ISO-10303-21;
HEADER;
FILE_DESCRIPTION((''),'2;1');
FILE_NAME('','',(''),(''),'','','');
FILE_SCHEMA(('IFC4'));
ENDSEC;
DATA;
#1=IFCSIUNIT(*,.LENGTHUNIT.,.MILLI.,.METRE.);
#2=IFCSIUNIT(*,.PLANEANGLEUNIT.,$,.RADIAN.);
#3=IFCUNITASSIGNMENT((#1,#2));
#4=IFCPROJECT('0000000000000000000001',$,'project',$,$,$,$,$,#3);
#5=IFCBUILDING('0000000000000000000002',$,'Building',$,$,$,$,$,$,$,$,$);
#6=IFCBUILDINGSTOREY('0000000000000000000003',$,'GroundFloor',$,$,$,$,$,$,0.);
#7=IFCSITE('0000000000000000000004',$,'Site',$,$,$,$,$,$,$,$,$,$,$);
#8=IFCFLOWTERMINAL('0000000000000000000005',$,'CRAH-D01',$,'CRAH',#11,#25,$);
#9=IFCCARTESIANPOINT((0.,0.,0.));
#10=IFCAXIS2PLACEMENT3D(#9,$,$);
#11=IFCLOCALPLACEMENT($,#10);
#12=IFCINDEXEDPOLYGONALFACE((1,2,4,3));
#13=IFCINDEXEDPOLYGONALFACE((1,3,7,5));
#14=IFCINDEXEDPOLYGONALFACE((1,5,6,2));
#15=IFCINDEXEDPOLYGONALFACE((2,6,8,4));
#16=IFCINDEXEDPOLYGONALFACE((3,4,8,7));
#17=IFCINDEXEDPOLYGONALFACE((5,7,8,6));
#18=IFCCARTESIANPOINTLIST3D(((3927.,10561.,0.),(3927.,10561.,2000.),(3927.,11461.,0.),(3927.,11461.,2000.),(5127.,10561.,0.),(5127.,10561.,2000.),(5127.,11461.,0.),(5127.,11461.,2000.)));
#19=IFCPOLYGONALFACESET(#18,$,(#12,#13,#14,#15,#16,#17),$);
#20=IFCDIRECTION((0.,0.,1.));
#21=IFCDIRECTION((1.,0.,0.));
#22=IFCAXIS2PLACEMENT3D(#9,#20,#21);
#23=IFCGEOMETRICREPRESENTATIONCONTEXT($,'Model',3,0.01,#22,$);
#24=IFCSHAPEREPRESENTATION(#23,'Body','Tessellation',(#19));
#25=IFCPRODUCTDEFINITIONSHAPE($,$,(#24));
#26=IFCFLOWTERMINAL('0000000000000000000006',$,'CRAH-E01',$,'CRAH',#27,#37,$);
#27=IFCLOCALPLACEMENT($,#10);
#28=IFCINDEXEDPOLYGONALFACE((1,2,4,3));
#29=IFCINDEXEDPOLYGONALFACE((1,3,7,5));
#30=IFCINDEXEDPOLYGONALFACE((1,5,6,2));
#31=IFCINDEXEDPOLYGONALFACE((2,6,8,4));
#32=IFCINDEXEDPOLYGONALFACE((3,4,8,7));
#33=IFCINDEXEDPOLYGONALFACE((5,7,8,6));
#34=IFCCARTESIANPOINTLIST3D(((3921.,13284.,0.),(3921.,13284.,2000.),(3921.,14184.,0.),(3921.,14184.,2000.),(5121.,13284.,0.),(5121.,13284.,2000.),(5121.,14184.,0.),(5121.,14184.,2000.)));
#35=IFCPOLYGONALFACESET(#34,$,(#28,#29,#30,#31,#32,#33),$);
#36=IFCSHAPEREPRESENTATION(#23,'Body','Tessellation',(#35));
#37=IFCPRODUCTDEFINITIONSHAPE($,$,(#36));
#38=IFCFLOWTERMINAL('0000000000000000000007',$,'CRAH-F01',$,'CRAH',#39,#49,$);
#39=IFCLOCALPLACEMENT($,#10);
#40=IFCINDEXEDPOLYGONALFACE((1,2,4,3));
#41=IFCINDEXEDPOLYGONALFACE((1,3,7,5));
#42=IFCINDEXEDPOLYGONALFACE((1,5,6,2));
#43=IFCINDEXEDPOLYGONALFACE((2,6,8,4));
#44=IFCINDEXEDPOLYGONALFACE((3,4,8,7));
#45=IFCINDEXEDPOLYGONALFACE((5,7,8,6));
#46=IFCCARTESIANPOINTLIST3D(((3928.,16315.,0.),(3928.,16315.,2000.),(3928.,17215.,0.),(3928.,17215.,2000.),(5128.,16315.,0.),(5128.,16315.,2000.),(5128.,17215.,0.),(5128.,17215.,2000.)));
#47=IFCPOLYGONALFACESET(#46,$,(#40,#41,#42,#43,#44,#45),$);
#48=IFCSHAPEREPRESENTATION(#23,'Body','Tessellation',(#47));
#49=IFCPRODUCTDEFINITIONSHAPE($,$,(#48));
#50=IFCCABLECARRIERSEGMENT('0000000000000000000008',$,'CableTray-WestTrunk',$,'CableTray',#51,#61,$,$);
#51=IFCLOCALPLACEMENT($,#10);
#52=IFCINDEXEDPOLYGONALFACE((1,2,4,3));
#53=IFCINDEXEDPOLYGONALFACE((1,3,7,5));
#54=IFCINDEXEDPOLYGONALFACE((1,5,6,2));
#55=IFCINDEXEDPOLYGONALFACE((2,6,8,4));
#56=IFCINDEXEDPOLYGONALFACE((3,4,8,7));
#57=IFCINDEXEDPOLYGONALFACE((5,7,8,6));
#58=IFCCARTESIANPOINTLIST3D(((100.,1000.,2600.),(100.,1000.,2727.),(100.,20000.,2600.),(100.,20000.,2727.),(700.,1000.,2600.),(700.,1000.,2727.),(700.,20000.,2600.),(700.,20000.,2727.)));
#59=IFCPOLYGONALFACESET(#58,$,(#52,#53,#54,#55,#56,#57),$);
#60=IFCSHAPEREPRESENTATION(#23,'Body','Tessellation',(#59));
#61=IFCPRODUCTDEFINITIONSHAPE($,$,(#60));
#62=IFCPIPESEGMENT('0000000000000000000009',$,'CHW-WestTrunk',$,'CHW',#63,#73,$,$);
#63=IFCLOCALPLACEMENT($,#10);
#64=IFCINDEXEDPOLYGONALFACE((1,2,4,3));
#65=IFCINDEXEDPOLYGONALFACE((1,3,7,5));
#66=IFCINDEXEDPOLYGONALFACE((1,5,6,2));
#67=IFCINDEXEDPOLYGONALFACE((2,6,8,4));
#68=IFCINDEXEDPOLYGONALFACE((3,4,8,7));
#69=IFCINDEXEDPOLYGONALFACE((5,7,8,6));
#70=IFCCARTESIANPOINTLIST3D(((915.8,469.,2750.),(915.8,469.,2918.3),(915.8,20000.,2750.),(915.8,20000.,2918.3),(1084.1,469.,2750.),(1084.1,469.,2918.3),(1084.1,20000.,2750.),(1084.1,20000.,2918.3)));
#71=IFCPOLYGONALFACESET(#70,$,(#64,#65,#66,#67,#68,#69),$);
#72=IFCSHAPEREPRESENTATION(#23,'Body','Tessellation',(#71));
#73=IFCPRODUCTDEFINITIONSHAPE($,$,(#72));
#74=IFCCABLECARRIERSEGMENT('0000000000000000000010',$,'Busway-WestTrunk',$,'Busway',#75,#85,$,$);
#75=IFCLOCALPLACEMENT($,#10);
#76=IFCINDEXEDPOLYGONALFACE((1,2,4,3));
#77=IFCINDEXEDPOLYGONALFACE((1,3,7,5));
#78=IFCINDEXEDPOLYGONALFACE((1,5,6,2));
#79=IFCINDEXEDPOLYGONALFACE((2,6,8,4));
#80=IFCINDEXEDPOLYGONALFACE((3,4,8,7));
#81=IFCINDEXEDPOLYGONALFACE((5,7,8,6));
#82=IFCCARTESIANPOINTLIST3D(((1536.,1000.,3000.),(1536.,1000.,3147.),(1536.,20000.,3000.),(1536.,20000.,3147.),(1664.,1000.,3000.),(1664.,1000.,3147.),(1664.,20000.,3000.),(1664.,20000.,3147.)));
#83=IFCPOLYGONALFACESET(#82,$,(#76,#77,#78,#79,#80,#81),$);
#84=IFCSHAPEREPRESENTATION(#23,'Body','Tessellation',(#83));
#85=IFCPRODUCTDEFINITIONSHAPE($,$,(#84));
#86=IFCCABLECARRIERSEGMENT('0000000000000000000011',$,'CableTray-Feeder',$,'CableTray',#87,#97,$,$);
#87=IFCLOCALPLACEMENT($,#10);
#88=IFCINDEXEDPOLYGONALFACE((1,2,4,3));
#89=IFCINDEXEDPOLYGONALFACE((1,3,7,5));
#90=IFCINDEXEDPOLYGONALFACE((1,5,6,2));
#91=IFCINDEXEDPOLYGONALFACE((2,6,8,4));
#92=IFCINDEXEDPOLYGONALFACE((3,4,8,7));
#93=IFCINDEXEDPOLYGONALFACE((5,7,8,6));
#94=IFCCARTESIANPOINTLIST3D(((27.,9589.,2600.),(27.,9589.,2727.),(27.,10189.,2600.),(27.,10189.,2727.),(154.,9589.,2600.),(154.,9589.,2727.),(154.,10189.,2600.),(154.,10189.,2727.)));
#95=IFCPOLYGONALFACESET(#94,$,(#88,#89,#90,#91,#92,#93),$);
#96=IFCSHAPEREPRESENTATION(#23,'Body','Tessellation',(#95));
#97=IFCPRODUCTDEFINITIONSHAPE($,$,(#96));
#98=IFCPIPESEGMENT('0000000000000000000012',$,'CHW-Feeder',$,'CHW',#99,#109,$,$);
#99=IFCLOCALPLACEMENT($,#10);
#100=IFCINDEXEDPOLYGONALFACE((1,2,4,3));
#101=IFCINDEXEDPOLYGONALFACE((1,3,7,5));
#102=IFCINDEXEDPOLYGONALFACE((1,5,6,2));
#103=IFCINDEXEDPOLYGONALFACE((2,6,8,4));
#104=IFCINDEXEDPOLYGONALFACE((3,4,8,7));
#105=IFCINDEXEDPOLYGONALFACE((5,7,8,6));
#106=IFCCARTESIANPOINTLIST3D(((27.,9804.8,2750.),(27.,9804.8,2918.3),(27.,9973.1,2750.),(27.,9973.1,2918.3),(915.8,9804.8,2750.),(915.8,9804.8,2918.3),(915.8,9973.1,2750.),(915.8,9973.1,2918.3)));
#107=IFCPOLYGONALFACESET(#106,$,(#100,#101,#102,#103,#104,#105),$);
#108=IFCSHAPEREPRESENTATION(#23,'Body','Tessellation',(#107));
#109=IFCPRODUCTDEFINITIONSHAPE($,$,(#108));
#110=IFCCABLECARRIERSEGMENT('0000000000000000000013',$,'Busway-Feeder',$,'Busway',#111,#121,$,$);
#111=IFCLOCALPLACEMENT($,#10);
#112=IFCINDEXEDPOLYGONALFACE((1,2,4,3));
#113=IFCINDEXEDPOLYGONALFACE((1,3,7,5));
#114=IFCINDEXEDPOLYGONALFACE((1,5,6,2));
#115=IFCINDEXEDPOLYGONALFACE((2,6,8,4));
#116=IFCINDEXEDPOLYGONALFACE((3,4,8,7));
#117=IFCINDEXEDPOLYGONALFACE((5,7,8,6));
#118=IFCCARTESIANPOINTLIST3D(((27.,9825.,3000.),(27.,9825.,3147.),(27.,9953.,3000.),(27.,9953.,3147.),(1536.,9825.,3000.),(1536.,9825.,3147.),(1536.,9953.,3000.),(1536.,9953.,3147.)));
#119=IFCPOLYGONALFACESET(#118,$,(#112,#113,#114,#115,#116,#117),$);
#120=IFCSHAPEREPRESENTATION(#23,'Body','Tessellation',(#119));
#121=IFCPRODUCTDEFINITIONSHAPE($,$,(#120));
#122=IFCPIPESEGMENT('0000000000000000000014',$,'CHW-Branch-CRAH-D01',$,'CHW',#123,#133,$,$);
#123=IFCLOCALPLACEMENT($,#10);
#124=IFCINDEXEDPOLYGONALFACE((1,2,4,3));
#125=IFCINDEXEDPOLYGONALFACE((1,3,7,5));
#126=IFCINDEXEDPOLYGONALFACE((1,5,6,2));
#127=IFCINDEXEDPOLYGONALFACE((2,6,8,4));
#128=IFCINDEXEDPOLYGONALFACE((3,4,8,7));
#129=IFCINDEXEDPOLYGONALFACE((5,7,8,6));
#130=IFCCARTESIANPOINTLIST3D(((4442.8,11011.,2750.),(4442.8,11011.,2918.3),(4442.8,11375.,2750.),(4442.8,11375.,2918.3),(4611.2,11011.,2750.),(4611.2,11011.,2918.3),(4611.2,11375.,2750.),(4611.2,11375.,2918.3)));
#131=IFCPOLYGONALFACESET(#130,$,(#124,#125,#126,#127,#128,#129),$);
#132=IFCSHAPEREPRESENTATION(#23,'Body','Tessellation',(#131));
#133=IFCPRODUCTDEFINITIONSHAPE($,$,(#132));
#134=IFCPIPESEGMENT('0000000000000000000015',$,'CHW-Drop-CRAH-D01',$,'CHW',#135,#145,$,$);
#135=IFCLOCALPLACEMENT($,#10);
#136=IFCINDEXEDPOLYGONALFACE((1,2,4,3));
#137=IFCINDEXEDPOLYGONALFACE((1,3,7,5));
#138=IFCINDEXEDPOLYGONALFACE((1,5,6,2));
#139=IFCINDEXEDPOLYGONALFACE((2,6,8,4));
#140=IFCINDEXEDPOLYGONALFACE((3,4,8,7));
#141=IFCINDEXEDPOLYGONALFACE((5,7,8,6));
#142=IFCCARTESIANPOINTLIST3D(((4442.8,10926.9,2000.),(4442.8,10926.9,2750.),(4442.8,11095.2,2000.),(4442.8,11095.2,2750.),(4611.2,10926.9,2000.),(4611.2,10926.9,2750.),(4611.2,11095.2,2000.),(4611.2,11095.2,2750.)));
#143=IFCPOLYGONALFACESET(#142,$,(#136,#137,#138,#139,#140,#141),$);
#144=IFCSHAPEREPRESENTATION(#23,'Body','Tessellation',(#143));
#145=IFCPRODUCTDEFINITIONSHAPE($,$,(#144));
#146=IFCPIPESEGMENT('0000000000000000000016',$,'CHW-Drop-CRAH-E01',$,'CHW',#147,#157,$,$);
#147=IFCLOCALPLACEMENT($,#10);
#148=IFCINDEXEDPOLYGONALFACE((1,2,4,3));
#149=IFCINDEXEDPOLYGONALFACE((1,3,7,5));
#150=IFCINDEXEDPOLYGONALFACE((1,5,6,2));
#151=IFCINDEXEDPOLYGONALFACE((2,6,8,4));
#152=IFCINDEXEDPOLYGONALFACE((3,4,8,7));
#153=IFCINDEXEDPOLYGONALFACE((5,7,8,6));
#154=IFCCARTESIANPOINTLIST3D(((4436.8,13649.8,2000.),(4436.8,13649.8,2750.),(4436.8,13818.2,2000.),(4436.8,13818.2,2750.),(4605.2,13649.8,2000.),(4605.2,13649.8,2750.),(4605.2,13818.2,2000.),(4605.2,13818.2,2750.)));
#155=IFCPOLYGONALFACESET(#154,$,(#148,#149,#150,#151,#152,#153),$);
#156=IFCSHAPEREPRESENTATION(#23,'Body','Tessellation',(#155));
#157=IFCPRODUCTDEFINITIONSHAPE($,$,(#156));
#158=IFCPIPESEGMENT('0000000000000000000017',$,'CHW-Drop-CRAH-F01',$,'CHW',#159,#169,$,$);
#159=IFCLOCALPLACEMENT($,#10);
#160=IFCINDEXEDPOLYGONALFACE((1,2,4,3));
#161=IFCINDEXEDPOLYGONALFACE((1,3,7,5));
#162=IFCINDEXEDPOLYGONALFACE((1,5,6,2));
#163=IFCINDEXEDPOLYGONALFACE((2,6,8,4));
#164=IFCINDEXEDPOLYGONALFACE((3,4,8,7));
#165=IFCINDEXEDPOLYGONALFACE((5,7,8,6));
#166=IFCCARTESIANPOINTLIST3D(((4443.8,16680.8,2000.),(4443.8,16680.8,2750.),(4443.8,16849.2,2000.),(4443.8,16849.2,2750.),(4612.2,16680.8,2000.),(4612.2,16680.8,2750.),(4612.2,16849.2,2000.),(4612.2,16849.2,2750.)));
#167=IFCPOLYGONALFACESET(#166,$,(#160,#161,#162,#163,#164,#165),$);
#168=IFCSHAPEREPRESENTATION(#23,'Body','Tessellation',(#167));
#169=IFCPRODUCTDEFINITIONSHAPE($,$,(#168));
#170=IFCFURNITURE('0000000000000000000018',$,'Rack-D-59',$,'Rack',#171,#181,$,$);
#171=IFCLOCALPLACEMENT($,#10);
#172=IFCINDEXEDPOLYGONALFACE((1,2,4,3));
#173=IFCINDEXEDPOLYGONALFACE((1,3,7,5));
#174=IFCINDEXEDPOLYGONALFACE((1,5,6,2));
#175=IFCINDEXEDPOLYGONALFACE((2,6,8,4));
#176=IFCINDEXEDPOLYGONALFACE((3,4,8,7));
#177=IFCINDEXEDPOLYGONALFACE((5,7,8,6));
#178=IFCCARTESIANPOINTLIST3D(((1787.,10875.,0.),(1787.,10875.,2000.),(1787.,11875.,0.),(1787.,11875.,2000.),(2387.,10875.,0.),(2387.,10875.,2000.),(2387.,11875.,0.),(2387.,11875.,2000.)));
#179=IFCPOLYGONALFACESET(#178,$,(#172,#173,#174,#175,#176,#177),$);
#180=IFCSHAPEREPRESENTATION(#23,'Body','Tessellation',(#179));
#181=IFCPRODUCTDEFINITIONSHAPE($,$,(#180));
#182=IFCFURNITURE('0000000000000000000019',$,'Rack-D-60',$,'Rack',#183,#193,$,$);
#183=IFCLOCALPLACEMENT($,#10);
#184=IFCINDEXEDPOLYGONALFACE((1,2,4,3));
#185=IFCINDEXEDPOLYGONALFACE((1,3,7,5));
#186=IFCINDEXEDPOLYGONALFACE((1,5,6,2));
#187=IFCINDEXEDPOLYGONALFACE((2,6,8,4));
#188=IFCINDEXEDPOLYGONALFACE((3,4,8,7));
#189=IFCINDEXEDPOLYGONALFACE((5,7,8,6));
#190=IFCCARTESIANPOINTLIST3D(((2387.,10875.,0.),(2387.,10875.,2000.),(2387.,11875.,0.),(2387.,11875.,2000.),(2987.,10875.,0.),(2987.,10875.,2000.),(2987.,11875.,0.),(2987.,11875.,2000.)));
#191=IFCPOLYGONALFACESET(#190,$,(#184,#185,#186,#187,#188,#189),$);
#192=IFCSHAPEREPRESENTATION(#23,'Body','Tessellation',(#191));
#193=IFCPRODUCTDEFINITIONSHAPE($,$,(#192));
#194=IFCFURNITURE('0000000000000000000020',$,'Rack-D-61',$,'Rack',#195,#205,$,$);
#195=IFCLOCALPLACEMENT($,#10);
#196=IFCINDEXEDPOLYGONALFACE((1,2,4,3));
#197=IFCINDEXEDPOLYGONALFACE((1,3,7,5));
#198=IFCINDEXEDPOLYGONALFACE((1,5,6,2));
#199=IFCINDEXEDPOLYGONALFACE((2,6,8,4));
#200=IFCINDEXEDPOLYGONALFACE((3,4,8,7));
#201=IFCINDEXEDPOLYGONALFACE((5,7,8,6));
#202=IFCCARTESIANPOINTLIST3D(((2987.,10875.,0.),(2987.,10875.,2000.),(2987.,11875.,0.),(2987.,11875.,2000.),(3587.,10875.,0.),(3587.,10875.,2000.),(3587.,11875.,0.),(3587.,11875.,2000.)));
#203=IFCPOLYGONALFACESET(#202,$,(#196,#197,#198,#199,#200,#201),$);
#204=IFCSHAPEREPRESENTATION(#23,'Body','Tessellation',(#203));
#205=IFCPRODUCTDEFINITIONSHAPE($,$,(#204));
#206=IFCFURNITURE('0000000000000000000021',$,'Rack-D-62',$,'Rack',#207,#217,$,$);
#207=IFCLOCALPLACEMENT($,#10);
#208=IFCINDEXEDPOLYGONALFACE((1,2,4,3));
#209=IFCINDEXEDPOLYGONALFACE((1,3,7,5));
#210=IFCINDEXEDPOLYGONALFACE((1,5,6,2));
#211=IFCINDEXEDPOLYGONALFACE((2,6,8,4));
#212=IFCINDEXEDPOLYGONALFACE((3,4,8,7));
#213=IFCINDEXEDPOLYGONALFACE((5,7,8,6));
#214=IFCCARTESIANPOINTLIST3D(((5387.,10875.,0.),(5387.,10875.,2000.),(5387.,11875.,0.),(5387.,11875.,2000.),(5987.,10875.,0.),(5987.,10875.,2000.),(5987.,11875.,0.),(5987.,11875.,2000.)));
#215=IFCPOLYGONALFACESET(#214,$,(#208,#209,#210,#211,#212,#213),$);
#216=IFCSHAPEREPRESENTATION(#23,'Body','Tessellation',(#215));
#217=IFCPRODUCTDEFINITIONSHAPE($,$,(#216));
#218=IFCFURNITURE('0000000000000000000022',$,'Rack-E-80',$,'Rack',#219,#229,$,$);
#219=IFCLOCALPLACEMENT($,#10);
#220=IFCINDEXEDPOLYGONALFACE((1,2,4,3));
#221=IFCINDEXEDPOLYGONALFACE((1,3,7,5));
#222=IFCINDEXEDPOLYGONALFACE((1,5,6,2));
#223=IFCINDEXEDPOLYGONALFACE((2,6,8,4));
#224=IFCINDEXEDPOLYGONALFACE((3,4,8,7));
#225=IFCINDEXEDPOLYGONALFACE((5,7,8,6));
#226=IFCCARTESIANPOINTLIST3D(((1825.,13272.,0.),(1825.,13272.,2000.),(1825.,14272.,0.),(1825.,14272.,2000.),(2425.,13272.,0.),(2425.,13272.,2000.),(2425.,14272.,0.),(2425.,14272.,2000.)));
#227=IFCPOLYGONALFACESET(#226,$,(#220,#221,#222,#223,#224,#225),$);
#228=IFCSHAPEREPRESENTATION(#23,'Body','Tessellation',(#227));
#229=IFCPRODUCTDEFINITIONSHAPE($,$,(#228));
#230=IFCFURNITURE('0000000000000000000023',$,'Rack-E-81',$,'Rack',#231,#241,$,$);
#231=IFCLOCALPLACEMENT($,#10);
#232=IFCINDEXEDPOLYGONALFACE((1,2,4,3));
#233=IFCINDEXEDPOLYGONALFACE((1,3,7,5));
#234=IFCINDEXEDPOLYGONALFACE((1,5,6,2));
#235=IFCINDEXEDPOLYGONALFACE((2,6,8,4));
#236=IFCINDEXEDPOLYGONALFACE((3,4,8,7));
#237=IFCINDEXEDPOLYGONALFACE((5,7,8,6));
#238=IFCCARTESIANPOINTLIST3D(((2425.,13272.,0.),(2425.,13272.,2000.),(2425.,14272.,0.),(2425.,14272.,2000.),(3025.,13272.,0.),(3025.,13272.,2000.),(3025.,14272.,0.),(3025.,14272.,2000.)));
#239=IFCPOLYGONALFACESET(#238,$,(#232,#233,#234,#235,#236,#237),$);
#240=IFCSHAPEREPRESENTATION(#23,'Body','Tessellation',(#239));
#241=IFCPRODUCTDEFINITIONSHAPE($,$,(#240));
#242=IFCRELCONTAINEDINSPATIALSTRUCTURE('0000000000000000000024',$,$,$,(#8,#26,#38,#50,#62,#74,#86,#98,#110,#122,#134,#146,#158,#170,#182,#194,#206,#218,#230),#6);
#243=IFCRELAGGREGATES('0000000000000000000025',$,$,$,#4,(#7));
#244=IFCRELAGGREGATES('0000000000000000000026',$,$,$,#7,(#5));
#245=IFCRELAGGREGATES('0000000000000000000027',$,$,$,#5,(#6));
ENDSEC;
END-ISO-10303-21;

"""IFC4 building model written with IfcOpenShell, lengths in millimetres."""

from ifc_helpers import new_model, si_unit, frame, origin, origin_with_axes, origin_2d, place, context, project, spatial, rectangle, extrude, element, save


model = new_model("IFC4")

# Units and contexts
model_context = context("Model", 3, precision=0.01, world=origin_with_axes())
ifc_project = project(units=[si_unit("LENGTHUNIT", "METRE", prefix="MILLI"), si_unit("PLANEANGLEUNIT", "RADIAN")])

# Site, building, storey
site = spatial("IfcSite", under=ifc_project, Name="Site")
building = spatial("IfcBuilding", under=site, Name="Building")
storey = spatial("IfcBuildingStorey", under=building, Name="GroundFloor", Elevation=0.0)

# Flow terminals
for number, where, z_axis, x_axis, name in (
    (1, (4527.0, 11011.0, 0.0), (0.0, 0.0, 1.0), (1.0, 0.0, 0.0), "CRAH-D01"),
    (2, (4521.0, 13734.0, 0.0), (0.0, 0.0, 1.0), (1.0, 0.0, 0.0), "CRAH-E01"),
    (3, (4528.0, 16765.0, 0.0), (0.0, 0.0, 1.0), (1.0, 0.0, 0.0), "CRAH-F01"),
):
    element("IfcFlowTerminal", number, at=place(None, frame(where, z_axis=z_axis, x_axis=x_axis)), inside=storey, Name=name, ObjectType="CRAH", context=model_context, shape_type="SweptSolid", body=[
        extrude(rectangle(XDim=1200.0, YDim=900.0, at=origin_2d()), origin(), (0.0, 0.0, 1.0), 2000.0),
    ])

# Cable carrier segment
cable_carrier_segment_1_placement = place(None, frame((400.0, 10500.0, 2600.0), z_axis=(0.0, 0.0, 1.0), x_axis=(1.0, 0.0, 0.0)))
element("IfcCableCarrierSegment", 4, at=cable_carrier_segment_1_placement, inside=storey, Name="CableTray-WestTrunk", ObjectType="CableTray", context=model_context, shape_type="SweptSolid", body=[
    extrude(rectangle(XDim=600.0, YDim=19000.0, at=origin_2d()), origin(), (0.0, 0.0, 1.0), 127.0),
])

# Pipe segment
pipe_segment_1_placement = place(None, frame((1000.0, 10234.5, 2750.0), z_axis=(0.0, 0.0, 1.0), x_axis=(1.0, 0.0, 0.0)))
element("IfcPipeSegment", 5, at=pipe_segment_1_placement, inside=storey, Name="CHW-WestTrunk", ObjectType="CHW", context=model_context, shape_type="SweptSolid", body=[
    extrude(rectangle(XDim=168.3, YDim=19531.0, at=origin_2d()), origin(), (0.0, 0.0, 1.0), 168.3),
])

# Cable carrier segments
cable_carrier_segment_2_placement = place(None, frame((1600.0, 10500.0, 3000.0), z_axis=(0.0, 0.0, 1.0), x_axis=(1.0, 0.0, 0.0)))
element("IfcCableCarrierSegment", 6, at=cable_carrier_segment_2_placement, inside=storey, Name="Busway-WestTrunk", ObjectType="Busway", context=model_context, shape_type="SweptSolid", body=[
    extrude(rectangle(XDim=128.0, YDim=19000.0, at=origin_2d()), origin(), (0.0, 0.0, 1.0), 147.0),
])
cable_carrier_segment_3_placement = place(None, frame((90.5, 9889.0, 2600.0), z_axis=(0.0, 0.0, 1.0), x_axis=(1.0, 0.0, 0.0)))
element("IfcCableCarrierSegment", 7, at=cable_carrier_segment_3_placement, inside=storey, Name="CableTray-Feeder", ObjectType="CableTray", context=model_context, shape_type="SweptSolid", body=[
    extrude(rectangle(XDim=127.0, YDim=600.0, at=origin_2d()), origin(), (0.0, 0.0, 1.0), 127.0),
])

# Pipe segment
pipe_segment_2_placement = place(None, frame((471.4, 9889.0, 2750.0), z_axis=(0.0, 0.0, 1.0), x_axis=(1.0, 0.0, 0.0)))
element("IfcPipeSegment", 8, at=pipe_segment_2_placement, inside=storey, Name="CHW-Feeder", ObjectType="CHW", context=model_context, shape_type="SweptSolid", body=[
    extrude(rectangle(XDim=888.9, YDim=168.3, at=origin_2d()), origin(), (0.0, 0.0, 1.0), 168.3),
])

# Cable carrier segment
cable_carrier_segment_4_placement = place(None, frame((781.5, 9889.0, 3000.0), z_axis=(0.0, 0.0, 1.0), x_axis=(1.0, 0.0, 0.0)))
element("IfcCableCarrierSegment", 9, at=cable_carrier_segment_4_placement, inside=storey, Name="Busway-Feeder", ObjectType="Busway", context=model_context, shape_type="SweptSolid", body=[
    extrude(rectangle(XDim=1509.0, YDim=128.0, at=origin_2d()), origin(), (0.0, 0.0, 1.0), 147.0),
])

# Pipe segments
pipe_segment_3_placement = place(None, frame((4527.0, 11193.0, 2750.0), z_axis=(0.0, 0.0, 1.0), x_axis=(1.0, 0.0, 0.0)))
element("IfcPipeSegment", 10, at=pipe_segment_3_placement, inside=storey, Name="CHW-Branch-CRAH-D01", ObjectType="CHW", context=model_context, shape_type="SweptSolid", body=[
    extrude(rectangle(XDim=168.3, YDim=364.0, at=origin_2d()), origin(), (0.0, 0.0, 1.0), 168.3),
])
for number, where, z_axis, x_axis, name in (
    (11, (4527.0, 11011.0, 2000.0), (0.0, 0.0, 1.0), (1.0, 0.0, 0.0), "CHW-Drop-CRAH-D01"),
    (12, (4521.0, 13734.0, 2000.0), (0.0, 0.0, 1.0), (1.0, 0.0, 0.0), "CHW-Drop-CRAH-E01"),
    (13, (4528.0, 16765.0, 2000.0), (0.0, 0.0, 1.0), (1.0, 0.0, 0.0), "CHW-Drop-CRAH-F01"),
):
    element("IfcPipeSegment", number, at=place(None, frame(where, z_axis=z_axis, x_axis=x_axis)), inside=storey, Name=name, ObjectType="CHW", context=model_context, shape_type="SweptSolid", body=[
        extrude(rectangle(XDim=168.3, YDim=168.3, at=origin_2d()), origin(), (0.0, 0.0, 1.0), 750.0),
    ])

# Furniture
for number, where, z_axis, x_axis, name in (
    (14, (2087.0, 11375.0, 0.0), (0.0, 0.0, 1.0), (1.0, 0.0, 0.0), "Rack-D-59"),
    (15, (2687.0, 11375.0, 0.0), (0.0, 0.0, 1.0), (1.0, 0.0, 0.0), "Rack-D-60"),
    (16, (3287.0, 11375.0, 0.0), (0.0, 0.0, 1.0), (1.0, 0.0, 0.0), "Rack-D-61"),
    (17, (5687.0, 11375.0, 0.0), (0.0, 0.0, 1.0), (1.0, 0.0, 0.0), "Rack-D-62"),
    (18, (2125.0, 13772.0, 0.0), (0.0, 0.0, 1.0), (1.0, 0.0, 0.0), "Rack-E-80"),
    (19, (2725.0, 13772.0, 0.0), (0.0, 0.0, 1.0), (1.0, 0.0, 0.0), "Rack-E-81"),
):
    element("IfcFurniture", number, at=place(None, frame(where, z_axis=z_axis, x_axis=x_axis)), inside=storey, Name=name, ObjectType="Rack", context=model_context, shape_type="SweptSolid", body=[
        extrude(rectangle(XDim=600.0, YDim=1000.0, at=origin_2d()), origin(), (0.0, 0.0, 1.0), 2000.0),
    ])

save(model, "model.ifc")
